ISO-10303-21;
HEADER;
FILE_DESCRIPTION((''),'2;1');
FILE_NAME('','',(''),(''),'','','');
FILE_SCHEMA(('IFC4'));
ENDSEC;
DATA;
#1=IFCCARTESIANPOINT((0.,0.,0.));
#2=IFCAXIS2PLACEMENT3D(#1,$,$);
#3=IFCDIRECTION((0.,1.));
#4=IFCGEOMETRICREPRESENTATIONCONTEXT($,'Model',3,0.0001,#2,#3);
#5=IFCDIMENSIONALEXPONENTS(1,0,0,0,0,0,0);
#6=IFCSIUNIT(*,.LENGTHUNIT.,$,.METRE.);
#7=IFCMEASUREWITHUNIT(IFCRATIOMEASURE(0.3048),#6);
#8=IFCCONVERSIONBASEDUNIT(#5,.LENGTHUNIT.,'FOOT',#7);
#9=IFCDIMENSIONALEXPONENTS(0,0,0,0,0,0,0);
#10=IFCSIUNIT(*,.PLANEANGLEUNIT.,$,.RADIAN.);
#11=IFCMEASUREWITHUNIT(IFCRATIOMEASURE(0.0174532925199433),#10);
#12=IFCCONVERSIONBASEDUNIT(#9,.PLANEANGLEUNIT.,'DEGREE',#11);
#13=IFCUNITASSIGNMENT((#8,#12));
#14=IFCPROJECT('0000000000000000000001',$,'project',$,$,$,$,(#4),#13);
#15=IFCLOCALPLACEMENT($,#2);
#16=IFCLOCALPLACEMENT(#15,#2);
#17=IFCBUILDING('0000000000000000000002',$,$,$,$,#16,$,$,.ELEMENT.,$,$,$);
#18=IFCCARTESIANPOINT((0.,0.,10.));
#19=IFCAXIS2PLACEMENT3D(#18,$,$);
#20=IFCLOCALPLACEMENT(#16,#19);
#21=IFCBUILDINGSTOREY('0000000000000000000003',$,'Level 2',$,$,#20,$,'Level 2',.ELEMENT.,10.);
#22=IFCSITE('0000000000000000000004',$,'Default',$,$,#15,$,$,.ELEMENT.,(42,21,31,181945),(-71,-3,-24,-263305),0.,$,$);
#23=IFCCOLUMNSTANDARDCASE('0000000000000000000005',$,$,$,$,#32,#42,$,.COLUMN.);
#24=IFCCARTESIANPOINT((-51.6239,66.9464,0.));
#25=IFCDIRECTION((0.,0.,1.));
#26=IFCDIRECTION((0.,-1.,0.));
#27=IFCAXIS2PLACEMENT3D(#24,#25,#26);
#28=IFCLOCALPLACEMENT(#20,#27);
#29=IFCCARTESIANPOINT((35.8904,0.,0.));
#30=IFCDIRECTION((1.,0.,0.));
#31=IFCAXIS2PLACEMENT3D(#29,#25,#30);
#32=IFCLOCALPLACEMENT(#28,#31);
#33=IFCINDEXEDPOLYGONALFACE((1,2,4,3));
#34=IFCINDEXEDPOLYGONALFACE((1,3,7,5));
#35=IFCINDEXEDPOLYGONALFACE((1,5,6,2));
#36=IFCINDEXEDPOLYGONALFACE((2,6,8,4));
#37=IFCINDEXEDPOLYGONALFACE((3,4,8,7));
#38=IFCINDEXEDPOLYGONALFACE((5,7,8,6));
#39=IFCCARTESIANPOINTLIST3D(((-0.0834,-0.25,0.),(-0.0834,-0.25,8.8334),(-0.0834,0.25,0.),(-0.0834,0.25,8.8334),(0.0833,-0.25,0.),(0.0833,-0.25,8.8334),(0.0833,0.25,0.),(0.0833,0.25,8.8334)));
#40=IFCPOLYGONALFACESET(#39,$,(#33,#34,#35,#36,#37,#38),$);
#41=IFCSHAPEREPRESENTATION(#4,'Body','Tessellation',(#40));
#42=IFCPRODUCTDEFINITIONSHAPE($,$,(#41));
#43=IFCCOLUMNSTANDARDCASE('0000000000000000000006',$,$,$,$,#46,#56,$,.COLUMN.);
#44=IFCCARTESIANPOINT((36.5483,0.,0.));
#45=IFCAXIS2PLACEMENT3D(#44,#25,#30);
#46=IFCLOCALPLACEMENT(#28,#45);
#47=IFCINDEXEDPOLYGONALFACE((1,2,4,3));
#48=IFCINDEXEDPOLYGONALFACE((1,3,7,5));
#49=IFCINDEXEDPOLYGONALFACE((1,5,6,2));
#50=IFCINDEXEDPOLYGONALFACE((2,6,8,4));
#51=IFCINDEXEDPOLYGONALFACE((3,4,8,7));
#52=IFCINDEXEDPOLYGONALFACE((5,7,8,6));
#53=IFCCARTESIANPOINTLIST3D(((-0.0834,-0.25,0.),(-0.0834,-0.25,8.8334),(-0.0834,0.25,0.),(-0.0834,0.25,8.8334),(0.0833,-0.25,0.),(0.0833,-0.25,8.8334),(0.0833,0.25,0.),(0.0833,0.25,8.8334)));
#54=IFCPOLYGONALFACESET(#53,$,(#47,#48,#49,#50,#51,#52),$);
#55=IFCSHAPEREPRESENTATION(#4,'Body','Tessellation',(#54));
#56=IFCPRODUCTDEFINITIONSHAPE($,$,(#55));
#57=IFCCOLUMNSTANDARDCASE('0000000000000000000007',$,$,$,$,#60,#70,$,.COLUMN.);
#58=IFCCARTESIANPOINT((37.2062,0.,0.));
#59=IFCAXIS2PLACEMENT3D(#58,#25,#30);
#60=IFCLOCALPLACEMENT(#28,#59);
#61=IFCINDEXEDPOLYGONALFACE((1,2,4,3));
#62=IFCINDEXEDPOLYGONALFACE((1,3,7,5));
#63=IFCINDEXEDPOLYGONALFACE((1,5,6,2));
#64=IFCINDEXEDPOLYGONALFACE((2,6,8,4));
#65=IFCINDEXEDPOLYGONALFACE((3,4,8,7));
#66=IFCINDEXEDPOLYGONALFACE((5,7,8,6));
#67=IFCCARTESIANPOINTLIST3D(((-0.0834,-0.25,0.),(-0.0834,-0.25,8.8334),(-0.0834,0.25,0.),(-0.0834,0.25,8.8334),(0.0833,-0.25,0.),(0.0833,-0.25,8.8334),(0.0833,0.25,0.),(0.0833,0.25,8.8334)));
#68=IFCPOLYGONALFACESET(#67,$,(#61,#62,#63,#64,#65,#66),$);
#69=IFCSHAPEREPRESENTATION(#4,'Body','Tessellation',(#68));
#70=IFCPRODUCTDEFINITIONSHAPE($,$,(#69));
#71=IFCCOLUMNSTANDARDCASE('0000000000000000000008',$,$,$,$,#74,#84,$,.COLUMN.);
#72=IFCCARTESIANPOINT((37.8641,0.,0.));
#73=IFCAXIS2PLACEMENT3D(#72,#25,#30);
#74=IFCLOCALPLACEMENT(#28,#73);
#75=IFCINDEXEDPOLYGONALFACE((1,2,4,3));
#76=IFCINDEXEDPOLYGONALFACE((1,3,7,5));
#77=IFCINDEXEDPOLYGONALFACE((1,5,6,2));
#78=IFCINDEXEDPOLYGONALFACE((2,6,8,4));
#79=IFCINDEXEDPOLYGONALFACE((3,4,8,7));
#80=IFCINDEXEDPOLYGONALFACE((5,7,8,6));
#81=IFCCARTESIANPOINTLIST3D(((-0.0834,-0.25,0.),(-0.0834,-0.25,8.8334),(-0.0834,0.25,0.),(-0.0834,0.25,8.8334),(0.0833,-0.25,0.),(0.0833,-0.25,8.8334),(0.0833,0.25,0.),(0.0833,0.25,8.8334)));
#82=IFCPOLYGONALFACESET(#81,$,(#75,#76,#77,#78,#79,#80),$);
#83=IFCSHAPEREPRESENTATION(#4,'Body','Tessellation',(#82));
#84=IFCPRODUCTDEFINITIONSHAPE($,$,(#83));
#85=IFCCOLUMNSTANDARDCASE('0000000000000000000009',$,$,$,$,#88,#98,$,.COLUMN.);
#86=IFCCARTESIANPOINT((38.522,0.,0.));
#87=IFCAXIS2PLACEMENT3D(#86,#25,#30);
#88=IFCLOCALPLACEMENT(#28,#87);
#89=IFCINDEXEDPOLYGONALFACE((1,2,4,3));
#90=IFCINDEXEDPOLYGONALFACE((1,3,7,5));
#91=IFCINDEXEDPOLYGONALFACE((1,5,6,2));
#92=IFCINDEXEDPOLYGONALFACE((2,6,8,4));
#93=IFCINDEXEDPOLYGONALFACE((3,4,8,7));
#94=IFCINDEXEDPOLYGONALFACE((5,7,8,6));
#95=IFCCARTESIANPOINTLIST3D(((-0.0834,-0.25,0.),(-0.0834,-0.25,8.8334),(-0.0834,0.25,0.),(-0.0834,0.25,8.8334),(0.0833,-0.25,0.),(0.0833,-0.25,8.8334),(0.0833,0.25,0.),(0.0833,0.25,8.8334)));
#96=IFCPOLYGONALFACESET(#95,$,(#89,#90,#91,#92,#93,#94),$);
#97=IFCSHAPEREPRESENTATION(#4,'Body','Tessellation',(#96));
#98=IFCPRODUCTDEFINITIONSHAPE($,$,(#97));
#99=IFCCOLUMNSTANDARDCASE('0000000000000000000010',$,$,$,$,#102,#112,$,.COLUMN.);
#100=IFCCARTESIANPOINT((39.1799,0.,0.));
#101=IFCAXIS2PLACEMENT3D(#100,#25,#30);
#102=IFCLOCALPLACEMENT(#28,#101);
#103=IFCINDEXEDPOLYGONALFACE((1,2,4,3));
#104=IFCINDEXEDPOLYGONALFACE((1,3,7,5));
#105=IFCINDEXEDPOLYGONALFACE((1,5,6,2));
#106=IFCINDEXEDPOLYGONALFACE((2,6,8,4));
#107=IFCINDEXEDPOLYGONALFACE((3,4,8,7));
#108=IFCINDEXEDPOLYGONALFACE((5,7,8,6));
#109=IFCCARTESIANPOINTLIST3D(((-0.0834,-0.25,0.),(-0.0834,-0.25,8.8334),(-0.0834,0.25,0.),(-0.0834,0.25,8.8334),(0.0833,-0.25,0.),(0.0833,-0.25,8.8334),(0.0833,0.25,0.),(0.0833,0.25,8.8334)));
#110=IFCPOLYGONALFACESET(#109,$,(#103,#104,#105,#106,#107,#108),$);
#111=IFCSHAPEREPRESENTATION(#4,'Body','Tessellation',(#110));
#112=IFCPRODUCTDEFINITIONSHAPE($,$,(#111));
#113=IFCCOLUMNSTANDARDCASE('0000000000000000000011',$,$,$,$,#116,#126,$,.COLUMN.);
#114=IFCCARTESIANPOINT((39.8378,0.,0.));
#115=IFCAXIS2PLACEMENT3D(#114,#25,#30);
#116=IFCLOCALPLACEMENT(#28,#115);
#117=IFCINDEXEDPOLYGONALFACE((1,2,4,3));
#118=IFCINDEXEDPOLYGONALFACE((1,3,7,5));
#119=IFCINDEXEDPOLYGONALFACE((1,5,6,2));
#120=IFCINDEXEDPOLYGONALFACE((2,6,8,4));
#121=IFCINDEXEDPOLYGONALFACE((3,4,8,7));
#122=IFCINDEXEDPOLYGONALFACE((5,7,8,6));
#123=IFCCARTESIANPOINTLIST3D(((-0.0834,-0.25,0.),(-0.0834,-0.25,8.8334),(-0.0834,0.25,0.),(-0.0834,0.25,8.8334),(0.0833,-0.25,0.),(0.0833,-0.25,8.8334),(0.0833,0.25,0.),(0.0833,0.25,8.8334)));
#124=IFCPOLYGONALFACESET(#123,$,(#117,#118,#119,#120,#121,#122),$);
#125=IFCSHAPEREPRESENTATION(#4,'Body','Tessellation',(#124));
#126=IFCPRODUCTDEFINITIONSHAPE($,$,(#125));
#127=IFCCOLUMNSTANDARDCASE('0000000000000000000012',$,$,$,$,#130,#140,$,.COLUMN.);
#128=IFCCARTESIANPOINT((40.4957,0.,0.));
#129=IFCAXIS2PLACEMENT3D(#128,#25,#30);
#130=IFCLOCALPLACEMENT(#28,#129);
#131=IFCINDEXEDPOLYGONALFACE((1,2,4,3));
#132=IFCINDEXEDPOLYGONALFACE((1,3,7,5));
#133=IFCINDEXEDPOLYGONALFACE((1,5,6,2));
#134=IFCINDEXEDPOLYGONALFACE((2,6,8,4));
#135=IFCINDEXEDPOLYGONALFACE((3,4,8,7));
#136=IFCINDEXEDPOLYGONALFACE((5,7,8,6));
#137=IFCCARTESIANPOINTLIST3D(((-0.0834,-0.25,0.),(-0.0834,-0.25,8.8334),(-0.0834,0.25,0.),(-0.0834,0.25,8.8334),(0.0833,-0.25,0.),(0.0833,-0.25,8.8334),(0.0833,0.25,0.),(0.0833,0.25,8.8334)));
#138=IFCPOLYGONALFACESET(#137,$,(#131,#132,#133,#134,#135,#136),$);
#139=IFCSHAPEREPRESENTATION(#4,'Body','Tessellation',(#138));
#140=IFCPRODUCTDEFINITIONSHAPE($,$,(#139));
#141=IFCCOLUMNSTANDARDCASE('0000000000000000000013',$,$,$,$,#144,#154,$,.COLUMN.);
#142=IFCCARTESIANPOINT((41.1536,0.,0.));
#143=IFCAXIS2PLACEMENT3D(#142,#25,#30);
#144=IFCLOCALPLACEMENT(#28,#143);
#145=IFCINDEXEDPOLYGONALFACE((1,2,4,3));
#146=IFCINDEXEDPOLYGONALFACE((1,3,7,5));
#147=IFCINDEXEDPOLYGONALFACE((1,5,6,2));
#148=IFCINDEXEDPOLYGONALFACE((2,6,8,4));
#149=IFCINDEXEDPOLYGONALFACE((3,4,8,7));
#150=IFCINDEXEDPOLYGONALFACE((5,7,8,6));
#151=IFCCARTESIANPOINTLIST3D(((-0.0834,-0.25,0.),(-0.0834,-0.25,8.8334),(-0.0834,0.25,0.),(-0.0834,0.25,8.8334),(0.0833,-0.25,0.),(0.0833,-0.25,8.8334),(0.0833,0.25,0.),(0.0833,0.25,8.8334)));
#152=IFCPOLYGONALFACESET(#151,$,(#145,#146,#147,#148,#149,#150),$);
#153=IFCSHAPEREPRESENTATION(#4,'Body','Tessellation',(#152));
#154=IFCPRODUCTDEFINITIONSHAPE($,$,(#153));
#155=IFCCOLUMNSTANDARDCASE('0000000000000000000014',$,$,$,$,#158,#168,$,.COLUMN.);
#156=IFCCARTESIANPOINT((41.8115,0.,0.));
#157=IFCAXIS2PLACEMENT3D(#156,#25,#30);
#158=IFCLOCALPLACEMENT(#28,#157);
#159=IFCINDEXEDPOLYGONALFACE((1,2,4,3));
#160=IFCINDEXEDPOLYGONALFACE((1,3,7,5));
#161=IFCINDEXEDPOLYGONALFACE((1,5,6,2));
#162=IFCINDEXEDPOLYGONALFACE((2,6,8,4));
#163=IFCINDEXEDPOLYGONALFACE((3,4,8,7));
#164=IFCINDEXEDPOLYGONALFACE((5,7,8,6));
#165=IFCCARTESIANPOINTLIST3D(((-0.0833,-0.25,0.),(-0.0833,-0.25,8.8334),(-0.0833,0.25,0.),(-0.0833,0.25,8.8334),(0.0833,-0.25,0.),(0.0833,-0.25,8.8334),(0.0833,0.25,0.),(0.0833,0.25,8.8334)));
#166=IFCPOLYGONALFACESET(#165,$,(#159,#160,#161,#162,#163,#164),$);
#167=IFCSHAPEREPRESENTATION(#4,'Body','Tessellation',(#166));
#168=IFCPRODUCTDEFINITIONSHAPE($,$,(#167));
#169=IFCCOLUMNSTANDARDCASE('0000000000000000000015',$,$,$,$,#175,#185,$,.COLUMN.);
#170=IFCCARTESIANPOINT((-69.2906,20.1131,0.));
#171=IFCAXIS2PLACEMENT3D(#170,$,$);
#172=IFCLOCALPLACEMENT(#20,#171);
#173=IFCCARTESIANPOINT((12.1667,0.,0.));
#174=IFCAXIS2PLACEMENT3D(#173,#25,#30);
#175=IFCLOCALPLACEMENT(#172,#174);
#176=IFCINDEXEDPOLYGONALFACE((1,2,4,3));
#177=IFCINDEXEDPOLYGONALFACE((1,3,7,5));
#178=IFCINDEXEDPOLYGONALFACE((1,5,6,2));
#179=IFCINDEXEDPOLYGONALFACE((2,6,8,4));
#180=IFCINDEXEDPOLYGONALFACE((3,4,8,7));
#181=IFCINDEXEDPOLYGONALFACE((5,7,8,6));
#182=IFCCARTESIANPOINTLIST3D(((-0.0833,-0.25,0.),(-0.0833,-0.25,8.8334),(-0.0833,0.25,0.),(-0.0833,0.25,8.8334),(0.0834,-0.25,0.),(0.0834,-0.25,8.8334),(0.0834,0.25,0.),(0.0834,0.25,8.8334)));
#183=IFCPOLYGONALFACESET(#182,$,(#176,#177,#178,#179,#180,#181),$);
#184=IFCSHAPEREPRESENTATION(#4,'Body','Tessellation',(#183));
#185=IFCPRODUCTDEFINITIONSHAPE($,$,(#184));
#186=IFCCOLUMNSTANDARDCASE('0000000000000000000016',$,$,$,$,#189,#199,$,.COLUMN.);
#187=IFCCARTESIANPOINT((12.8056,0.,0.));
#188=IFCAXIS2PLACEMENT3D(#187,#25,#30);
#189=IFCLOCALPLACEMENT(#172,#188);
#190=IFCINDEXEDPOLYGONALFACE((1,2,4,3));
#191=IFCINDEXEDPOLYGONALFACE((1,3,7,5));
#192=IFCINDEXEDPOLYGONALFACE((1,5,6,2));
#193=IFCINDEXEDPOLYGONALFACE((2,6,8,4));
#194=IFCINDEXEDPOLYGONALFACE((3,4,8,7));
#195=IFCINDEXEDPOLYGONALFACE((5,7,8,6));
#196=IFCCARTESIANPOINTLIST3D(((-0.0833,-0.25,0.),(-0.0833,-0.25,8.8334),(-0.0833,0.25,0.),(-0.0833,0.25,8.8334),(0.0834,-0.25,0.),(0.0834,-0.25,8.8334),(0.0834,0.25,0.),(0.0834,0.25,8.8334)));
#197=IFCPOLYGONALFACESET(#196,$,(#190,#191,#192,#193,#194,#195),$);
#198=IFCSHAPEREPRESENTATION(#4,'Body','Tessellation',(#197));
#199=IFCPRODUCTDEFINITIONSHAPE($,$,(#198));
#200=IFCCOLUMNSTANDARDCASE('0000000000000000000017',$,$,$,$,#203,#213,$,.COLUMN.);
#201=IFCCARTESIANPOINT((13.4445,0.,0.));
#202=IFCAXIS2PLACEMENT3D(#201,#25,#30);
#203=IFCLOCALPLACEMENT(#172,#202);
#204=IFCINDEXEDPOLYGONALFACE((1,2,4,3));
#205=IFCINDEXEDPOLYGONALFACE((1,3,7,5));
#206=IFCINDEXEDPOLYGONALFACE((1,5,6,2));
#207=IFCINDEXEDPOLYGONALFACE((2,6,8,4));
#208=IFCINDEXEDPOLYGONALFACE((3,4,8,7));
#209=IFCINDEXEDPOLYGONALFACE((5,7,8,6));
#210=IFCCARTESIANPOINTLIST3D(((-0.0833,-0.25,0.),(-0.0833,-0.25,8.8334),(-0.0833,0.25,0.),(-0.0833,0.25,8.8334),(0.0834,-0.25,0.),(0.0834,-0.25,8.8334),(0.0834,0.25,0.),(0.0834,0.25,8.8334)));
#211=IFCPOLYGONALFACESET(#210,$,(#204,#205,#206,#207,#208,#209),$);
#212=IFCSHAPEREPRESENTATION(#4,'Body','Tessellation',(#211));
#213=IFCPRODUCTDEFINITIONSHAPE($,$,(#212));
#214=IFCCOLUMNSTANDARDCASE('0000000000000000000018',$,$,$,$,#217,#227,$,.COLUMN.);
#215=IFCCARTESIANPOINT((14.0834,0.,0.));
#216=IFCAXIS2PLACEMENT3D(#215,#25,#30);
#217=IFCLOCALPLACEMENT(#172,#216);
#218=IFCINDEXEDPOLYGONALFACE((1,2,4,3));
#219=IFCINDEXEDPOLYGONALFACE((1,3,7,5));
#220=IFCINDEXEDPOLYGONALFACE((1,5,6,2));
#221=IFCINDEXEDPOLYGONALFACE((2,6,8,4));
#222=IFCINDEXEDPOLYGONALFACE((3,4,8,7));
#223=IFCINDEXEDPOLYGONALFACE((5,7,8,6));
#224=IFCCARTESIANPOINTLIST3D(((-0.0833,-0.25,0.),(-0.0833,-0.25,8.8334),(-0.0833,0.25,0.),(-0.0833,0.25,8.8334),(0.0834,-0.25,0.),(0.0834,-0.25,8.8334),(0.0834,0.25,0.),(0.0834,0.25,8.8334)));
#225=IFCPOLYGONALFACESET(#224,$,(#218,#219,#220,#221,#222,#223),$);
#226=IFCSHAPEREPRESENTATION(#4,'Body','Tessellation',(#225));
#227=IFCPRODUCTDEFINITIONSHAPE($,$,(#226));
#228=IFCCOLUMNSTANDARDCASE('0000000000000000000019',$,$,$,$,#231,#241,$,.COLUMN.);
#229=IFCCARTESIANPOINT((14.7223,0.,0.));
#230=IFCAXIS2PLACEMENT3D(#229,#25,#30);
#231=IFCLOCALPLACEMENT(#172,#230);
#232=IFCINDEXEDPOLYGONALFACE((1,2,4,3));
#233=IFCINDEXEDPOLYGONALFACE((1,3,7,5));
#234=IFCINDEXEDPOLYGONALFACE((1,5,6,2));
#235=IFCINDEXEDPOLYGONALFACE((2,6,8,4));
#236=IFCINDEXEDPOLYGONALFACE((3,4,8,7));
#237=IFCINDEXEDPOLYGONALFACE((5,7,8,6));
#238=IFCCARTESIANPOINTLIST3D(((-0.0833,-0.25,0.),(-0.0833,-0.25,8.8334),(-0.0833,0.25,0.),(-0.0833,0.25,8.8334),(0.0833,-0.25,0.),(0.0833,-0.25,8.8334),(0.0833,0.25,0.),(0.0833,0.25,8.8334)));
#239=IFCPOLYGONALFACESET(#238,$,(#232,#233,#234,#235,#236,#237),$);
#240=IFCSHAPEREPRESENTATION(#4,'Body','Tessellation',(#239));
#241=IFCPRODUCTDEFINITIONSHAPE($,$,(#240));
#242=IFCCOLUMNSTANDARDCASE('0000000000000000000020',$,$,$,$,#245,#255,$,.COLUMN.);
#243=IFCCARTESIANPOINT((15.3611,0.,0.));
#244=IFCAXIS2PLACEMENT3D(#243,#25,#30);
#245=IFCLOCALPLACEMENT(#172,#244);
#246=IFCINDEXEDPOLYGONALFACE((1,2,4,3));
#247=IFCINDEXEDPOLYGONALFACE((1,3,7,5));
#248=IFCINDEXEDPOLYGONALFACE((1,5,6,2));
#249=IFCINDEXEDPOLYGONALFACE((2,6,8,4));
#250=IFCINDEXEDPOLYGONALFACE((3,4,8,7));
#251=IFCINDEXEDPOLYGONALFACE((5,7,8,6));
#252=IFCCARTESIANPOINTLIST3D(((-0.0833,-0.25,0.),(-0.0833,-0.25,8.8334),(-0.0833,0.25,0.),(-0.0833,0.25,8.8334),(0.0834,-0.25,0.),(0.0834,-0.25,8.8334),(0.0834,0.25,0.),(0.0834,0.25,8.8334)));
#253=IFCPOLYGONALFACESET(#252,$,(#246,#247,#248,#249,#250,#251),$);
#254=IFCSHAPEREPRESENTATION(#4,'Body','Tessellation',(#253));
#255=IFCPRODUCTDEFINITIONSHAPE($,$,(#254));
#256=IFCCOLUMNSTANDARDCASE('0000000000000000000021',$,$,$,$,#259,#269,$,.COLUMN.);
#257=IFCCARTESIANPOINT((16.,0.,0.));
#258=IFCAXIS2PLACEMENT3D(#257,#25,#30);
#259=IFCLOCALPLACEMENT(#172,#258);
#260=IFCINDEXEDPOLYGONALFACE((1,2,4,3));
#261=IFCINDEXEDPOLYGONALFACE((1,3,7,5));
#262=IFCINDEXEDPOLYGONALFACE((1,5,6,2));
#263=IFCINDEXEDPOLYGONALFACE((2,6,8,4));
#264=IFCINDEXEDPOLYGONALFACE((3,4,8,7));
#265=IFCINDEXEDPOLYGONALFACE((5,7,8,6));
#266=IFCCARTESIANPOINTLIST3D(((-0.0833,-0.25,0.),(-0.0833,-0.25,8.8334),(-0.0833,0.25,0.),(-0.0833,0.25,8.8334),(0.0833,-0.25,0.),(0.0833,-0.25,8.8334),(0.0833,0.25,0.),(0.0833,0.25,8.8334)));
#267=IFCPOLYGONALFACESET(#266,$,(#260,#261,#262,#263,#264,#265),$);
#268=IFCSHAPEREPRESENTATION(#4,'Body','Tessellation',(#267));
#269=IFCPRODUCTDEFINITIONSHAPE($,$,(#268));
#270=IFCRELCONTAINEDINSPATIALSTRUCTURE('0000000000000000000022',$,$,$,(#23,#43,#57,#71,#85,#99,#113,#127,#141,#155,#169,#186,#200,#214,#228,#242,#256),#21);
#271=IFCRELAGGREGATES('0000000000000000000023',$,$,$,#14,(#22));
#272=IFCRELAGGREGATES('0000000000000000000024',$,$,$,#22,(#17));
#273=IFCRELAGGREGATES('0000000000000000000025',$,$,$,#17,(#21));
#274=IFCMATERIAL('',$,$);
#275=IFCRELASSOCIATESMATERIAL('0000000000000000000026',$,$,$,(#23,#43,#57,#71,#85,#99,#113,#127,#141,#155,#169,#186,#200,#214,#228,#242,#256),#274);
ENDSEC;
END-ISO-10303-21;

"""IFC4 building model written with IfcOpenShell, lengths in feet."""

from ifc_helpers import new_model, entity, si_unit, converted_unit, direction, frame, origin, place, context, project, spatial, rectangle, extrude, material, element, save


model = new_model("IFC4")

# Units and contexts
model_context = context("Model", 3, precision=0.0001, world=origin(), true_north=direction((0.0, 1.0)))
ifc_project = project(units=[converted_unit("LENGTHUNIT", "FOOT", entity("IfcRatioMeasure", 0.3048), si_unit("LENGTHUNIT", "METRE"), dimensions=[1, 0, 0, 0, 0, 0, 0]), converted_unit("PLANEANGLEUNIT", "DEGREE", entity("IfcRatioMeasure", 0.0174532925199433), si_unit("PLANEANGLEUNIT", "RADIAN"), dimensions=[0, 0, 0, 0, 0, 0, 0])], contexts=[model_context])

# Site, building, storey
site_placement = place(None, origin())
site = spatial("IfcSite", under=ifc_project, at=site_placement, Name="Default", CompositionType="ELEMENT", RefLatitude=(42, 21, 31, 181945), RefLongitude=(-71, -3, -24, -263305), RefElevation=0.0)
building_placement = place(site_placement, origin())
building = spatial("IfcBuilding", under=site, at=building_placement, CompositionType="ELEMENT")
storey_placement = place(building_placement, frame((0.0, 0.0, 10.0)))
storey = spatial("IfcBuildingStorey", under=building, at=storey_placement, Name="Level 2", LongName="Level 2", CompositionType="ELEMENT", Elevation=10.0)

# Columns
ifc_material_1 = material(Name="")
placement_1 = place(storey_placement, frame((-51.6239, 66.9464, 0.0), z_axis=(0.0, 0.0, 1.0), x_axis=(0.0, -1.0, 0.0)))
for number, where, z_axis, x_axis in (
    (1, (35.8904, 0.0, 0.0), (0.0, 0.0, 1.0), (1.0, 0.0, 0.0)),
    (2, (36.5483, 0.0, 0.0), (0.0, 0.0, 1.0), (1.0, 0.0, 0.0)),
    (3, (37.2062, 0.0, 0.0), (0.0, 0.0, 1.0), (1.0, 0.0, 0.0)),
    (4, (37.8641, 0.0, 0.0), (0.0, 0.0, 1.0), (1.0, 0.0, 0.0)),
    (5, (38.522, 0.0, 0.0), (0.0, 0.0, 1.0), (1.0, 0.0, 0.0)),
    (6, (39.1799, 0.0, 0.0), (0.0, 0.0, 1.0), (1.0, 0.0, 0.0)),
    (7, (39.8378, 0.0, 0.0), (0.0, 0.0, 1.0), (1.0, 0.0, 0.0)),
    (8, (40.4957, 0.0, 0.0), (0.0, 0.0, 1.0), (1.0, 0.0, 0.0)),
    (9, (41.1536, 0.0, 0.0), (0.0, 0.0, 1.0), (1.0, 0.0, 0.0)),
    (10, (41.8115, 0.0, 0.0), (0.0, 0.0, 1.0), (1.0, 0.0, 0.0)),
):
    element("IfcColumnStandardCase", number, at=place(placement_1, frame(where, z_axis=z_axis, x_axis=x_axis)), inside=storey, material=ifc_material_1, PredefinedType="COLUMN", context=model_context, shape_type="SweptSolid", body=[
        extrude(rectangle(XDim=0.1667, YDim=0.5), origin(), (0.0, 0.0, 1.0), 8.8334),
    ])
placement_2 = place(storey_placement, frame((-69.2906, 20.1131, 0.0)))
for number, where, z_axis, x_axis in (
    (11, (12.1667, 0.0, 0.0), (0.0, 0.0, 1.0), (1.0, 0.0, 0.0)),
    (12, (12.8056, 0.0, 0.0), (0.0, 0.0, 1.0), (1.0, 0.0, 0.0)),
    (13, (13.4445, 0.0, 0.0), (0.0, 0.0, 1.0), (1.0, 0.0, 0.0)),
    (14, (14.0834, 0.0, 0.0), (0.0, 0.0, 1.0), (1.0, 0.0, 0.0)),
    (15, (14.7223, 0.0, 0.0), (0.0, 0.0, 1.0), (1.0, 0.0, 0.0)),
    (16, (15.3611, 0.0, 0.0), (0.0, 0.0, 1.0), (1.0, 0.0, 0.0)),
    (17, (16.0, 0.0, 0.0), (0.0, 0.0, 1.0), (1.0, 0.0, 0.0)),
):
    element("IfcColumnStandardCase", number, at=place(placement_2, frame(where, z_axis=z_axis, x_axis=x_axis)), inside=storey, material=ifc_material_1, PredefinedType="COLUMN", context=model_context, shape_type="SweptSolid", body=[
        extrude(rectangle(XDim=0.1667, YDim=0.5), origin(), (0.0, 0.0, 1.0), 8.8334),
    ])

save(model, "model.ifc")
